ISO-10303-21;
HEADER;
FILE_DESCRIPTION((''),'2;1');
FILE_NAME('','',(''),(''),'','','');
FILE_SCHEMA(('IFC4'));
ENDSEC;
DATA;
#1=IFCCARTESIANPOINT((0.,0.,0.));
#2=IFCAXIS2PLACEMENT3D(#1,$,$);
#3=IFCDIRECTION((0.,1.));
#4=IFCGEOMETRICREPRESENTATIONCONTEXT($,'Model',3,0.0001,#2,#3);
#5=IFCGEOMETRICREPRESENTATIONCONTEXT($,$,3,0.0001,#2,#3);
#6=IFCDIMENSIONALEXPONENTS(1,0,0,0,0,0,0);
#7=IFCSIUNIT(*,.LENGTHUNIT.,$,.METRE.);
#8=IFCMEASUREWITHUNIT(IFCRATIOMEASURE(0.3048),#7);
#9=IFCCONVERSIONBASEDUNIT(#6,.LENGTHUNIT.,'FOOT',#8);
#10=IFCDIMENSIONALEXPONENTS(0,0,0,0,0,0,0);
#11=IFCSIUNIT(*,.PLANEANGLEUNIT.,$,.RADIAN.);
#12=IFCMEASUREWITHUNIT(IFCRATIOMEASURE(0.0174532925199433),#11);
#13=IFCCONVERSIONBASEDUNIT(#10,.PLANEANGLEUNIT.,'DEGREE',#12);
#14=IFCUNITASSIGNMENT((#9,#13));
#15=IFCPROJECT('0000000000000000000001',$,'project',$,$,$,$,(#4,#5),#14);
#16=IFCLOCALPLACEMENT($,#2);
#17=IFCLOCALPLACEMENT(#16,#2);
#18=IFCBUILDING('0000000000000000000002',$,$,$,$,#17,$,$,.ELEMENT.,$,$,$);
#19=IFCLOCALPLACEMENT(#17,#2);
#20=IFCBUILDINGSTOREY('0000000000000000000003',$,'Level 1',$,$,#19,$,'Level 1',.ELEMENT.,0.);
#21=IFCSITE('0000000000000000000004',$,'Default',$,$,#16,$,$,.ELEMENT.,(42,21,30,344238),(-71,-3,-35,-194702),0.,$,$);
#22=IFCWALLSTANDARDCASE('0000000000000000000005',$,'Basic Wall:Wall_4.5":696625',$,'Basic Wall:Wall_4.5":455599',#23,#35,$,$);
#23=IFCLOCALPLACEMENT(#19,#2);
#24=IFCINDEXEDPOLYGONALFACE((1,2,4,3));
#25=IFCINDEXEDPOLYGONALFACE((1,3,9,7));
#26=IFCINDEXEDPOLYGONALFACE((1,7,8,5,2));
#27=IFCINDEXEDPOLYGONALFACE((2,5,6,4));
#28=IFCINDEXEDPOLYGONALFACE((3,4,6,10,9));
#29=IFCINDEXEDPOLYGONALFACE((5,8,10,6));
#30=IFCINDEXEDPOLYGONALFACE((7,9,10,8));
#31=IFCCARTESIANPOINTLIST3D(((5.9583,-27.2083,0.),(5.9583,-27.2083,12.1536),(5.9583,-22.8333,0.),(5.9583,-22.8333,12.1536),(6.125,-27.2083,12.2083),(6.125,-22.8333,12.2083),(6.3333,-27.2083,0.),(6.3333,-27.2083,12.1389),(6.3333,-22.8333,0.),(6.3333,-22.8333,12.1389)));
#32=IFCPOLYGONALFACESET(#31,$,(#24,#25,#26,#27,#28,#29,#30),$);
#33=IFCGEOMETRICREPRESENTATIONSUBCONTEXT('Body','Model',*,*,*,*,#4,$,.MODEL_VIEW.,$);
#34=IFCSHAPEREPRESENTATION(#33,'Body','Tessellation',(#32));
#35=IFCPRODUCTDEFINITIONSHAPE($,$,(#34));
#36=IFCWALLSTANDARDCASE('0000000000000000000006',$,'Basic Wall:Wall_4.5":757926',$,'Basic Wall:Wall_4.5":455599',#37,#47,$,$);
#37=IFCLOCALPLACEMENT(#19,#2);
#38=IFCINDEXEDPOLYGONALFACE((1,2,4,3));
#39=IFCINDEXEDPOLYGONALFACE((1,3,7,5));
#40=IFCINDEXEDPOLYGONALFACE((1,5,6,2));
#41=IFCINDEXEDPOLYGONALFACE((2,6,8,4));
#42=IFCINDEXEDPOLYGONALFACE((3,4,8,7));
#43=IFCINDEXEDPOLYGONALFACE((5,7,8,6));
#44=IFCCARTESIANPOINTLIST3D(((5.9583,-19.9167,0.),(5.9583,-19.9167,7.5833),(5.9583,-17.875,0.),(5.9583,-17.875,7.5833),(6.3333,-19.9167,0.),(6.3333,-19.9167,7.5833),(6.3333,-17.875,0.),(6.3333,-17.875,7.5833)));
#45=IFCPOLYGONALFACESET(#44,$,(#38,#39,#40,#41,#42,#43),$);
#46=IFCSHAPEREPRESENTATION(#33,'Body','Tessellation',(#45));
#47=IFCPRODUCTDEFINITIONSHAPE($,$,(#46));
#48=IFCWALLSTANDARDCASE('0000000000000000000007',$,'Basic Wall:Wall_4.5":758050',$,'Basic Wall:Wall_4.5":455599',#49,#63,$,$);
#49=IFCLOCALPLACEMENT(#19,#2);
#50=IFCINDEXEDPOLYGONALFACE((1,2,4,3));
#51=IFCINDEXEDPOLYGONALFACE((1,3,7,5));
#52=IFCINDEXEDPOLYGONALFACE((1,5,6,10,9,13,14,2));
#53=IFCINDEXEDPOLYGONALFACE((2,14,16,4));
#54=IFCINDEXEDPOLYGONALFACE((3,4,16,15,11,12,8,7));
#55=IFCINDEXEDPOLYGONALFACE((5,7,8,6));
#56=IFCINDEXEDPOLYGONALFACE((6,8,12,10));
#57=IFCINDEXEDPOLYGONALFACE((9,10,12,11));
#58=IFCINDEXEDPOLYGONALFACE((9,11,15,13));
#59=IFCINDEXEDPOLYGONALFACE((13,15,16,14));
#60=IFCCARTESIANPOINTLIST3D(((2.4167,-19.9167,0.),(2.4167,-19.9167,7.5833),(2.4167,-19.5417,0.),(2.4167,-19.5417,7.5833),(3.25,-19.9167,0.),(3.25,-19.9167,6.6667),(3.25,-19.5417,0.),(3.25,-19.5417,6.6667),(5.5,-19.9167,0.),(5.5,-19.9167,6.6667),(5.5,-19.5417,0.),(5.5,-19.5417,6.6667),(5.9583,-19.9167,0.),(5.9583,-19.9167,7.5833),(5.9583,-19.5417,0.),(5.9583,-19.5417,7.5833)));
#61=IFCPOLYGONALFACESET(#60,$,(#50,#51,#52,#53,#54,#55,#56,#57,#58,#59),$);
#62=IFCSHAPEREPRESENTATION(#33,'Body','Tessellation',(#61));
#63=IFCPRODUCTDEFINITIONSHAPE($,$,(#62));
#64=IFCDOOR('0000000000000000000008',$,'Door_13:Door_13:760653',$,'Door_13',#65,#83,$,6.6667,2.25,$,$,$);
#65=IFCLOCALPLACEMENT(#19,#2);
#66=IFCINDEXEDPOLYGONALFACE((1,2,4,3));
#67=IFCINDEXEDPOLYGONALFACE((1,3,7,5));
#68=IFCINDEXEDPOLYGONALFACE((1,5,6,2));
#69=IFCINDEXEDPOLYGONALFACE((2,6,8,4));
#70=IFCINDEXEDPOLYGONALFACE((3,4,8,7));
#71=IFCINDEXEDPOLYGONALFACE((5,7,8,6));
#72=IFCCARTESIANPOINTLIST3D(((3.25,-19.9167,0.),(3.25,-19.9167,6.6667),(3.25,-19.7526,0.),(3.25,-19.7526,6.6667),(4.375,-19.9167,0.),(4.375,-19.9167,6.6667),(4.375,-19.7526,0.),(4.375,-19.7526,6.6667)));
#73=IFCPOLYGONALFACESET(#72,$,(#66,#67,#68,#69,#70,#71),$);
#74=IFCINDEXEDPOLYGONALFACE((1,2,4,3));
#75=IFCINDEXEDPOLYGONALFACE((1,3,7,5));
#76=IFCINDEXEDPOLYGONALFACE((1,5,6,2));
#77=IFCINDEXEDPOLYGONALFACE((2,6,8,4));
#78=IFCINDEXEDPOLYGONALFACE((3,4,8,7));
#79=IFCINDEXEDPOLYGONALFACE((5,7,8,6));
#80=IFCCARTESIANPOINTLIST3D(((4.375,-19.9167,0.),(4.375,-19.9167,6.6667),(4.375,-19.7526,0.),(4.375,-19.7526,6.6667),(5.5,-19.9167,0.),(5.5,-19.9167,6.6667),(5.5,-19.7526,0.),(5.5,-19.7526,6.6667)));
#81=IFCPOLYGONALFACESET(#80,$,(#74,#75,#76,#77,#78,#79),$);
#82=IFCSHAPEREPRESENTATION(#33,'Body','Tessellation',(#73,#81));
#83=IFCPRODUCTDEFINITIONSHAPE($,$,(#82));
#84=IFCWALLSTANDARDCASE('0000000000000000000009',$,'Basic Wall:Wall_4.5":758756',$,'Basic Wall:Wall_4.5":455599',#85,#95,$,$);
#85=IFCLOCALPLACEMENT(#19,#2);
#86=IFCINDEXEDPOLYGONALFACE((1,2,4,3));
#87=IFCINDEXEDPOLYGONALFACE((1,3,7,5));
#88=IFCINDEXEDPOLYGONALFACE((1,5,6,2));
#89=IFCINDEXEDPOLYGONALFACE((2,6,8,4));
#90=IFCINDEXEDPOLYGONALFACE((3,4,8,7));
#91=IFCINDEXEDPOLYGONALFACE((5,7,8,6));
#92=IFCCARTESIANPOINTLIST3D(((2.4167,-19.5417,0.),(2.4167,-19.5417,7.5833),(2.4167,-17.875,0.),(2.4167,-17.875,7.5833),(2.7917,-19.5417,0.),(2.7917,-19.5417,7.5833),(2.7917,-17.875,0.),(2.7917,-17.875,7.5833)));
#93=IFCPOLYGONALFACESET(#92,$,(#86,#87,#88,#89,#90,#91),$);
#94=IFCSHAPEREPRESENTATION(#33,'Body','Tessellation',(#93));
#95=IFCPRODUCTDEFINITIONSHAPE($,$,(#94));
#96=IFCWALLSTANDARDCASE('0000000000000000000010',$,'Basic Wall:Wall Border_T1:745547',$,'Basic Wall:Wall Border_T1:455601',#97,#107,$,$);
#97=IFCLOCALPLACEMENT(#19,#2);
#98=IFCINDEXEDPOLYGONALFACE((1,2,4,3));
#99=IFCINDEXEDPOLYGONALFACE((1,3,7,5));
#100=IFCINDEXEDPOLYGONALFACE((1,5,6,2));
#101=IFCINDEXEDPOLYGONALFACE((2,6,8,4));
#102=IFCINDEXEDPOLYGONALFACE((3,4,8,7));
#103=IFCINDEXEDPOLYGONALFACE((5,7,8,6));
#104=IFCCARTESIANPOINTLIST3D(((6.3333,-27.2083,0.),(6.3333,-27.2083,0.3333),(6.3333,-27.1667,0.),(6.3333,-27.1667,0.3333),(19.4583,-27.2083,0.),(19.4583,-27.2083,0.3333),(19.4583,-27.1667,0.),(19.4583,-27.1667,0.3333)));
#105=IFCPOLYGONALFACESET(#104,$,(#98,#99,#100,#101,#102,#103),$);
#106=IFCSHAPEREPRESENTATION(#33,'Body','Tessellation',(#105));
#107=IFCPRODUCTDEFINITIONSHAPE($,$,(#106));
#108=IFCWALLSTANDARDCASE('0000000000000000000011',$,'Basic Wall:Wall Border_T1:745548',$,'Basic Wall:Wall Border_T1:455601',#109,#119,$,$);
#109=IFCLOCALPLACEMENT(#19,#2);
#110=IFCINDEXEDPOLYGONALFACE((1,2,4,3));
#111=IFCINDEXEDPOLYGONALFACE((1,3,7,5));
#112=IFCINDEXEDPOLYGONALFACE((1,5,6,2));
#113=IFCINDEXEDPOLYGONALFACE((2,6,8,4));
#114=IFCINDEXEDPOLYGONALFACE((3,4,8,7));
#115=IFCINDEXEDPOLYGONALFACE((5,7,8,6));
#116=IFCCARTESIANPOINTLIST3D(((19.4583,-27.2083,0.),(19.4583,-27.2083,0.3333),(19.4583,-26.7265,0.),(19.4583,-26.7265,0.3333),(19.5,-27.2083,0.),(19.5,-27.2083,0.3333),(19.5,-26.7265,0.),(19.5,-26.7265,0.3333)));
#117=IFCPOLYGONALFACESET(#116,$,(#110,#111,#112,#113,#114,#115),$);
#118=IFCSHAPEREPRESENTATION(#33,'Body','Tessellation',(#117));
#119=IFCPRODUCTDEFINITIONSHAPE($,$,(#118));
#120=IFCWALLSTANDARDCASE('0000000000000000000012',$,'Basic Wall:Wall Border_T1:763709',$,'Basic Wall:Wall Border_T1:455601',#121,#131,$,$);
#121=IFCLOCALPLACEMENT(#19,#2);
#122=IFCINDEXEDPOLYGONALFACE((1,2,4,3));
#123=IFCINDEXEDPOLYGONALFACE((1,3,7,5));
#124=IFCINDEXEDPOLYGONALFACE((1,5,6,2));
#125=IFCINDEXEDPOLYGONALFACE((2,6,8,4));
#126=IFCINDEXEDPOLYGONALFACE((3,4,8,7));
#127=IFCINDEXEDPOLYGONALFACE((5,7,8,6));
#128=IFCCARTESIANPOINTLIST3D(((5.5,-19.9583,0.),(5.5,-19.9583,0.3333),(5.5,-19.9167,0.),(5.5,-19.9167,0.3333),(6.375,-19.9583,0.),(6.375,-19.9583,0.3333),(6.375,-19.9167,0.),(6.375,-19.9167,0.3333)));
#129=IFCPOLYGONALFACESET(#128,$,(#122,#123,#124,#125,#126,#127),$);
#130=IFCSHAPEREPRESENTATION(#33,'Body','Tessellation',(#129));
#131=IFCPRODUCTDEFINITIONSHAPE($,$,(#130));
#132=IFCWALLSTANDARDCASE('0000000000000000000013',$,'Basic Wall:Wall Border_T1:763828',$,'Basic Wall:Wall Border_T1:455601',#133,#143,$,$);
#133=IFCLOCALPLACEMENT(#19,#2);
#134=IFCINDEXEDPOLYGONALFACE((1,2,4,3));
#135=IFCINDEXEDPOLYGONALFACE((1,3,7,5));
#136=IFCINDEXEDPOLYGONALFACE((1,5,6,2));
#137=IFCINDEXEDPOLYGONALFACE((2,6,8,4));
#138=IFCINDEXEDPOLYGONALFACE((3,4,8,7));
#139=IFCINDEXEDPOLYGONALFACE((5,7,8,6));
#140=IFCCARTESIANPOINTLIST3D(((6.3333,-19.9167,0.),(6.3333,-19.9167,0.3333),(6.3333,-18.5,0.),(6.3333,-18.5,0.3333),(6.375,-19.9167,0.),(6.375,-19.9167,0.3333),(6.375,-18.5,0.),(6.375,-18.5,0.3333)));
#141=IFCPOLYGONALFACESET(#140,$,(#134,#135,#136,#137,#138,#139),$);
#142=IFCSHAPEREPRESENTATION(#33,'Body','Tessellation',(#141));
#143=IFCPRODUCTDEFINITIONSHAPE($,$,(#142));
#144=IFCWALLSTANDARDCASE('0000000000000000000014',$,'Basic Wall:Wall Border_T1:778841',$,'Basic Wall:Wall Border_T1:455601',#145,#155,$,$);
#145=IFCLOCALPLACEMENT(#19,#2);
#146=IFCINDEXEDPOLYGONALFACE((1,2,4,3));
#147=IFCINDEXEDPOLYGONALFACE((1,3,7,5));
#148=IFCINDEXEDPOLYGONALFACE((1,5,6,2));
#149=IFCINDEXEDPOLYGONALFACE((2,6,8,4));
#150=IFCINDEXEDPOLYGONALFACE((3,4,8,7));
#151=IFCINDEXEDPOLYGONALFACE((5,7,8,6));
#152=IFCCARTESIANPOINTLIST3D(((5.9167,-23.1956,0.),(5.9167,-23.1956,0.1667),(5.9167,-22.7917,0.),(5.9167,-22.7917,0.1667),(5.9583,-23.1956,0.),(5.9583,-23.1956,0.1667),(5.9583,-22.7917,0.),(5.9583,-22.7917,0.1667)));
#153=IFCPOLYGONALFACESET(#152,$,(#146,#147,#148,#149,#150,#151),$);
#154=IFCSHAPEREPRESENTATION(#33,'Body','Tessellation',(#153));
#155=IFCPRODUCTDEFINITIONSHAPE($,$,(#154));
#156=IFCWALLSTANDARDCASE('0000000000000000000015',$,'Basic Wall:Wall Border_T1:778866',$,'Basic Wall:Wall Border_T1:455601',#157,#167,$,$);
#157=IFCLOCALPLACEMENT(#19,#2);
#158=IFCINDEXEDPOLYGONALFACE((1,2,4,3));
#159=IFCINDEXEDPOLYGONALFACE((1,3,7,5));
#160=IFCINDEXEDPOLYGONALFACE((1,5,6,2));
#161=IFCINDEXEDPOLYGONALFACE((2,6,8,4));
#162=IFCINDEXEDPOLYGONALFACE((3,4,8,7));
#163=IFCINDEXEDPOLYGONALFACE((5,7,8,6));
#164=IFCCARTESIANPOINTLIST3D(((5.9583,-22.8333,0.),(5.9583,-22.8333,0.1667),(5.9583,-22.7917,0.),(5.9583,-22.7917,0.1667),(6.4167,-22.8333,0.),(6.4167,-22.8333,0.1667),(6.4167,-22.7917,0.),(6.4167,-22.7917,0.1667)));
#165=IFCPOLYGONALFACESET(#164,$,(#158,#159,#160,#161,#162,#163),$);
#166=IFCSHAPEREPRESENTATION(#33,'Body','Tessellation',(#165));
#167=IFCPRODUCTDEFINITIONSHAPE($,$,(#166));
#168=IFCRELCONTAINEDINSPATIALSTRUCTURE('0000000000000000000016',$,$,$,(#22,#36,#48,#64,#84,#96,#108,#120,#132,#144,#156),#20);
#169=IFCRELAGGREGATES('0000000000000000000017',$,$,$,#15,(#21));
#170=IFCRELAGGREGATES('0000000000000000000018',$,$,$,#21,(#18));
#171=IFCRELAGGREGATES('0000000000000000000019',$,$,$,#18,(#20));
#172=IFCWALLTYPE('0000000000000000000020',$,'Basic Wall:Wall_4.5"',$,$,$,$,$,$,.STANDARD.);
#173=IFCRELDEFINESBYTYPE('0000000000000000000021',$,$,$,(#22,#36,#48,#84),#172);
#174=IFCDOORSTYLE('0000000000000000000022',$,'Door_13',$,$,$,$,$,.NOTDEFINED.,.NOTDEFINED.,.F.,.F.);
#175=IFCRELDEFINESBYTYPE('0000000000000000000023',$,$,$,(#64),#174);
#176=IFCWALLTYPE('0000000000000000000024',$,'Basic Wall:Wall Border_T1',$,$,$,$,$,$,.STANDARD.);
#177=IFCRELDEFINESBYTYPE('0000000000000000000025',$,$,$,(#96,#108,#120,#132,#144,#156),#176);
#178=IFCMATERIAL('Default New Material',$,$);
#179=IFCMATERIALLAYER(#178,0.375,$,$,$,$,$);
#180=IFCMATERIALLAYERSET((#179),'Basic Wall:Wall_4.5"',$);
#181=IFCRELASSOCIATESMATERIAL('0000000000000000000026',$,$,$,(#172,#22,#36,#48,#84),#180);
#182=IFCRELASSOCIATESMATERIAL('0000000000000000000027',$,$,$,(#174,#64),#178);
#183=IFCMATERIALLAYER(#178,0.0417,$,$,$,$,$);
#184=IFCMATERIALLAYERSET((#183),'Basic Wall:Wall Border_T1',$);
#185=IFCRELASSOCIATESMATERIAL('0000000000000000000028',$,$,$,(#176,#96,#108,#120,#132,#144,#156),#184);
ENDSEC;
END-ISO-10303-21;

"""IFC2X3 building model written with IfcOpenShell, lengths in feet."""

from ifc_helpers import new_model, entity, si_unit, converted_unit, direction, frame, frame_2d, origin, origin_2d_with_axis, place, context, subcontext, project, spatial, polyline, rectangle, extrude, clip, bounded_halfspace, source, transform, mapped, material, layer, layer_set, layer_usage, type_object, type_shapes, element, fill, save


model = new_model("IFC2X3")

# Units and contexts
model_context = context("Model", 3, precision=0.0001, world=origin(), true_north=direction((0.0, 1.0)))
context_of_model = context(None, 3, precision=0.0001, world=origin(), true_north=direction((0.0, 1.0)))
body_context = subcontext(model_context, "Body", "Model", "MODEL_VIEW")
ifc_project = project(units=[converted_unit("LENGTHUNIT", "FOOT", entity("IfcRatioMeasure", 0.3048), si_unit("LENGTHUNIT", "METRE"), dimensions=[1, 0, 0, 0, 0, 0, 0]), converted_unit("PLANEANGLEUNIT", "DEGREE", entity("IfcRatioMeasure", 0.0174532925199433), si_unit("PLANEANGLEUNIT", "RADIAN"), dimensions=[0, 0, 0, 0, 0, 0, 0])], contexts=[model_context, context_of_model])

# Site, building, storey
site_placement = place(None, origin())
site = spatial("IfcSite", under=ifc_project, at=site_placement, Name="Default", CompositionType="ELEMENT", RefLatitude=(42, 21, 30, 344238), RefLongitude=(-71, -3, -35, -194702), RefElevation=0.0)
building_placement = place(site_placement, origin())
building = spatial("IfcBuilding", under=site, at=building_placement, CompositionType="ELEMENT")
storey_placement = place(building_placement, origin())
storey = spatial("IfcBuildingStorey", under=building, at=storey_placement, Name="Level 1", LongName="Level 1", CompositionType="ELEMENT", Elevation=0.0)

# Walls
ifc_material = material(Name="Default New Material")
ifc_layer_1 = layer(ifc_material, 0.375)
ifc_layer_set_1 = layer_set([ifc_layer_1], Name="Basic Wall:Wall_4.5\"")
ifc_layer_usage_1 = layer_usage(ifc_layer_set_1, "AXIS2", "NEGATIVE", 0.1875)
wall_type_1 = type_object("IfcWallType", Name="Basic Wall:Wall_4.5\"", PredefinedType="STANDARD", material=ifc_layer_set_1)
wall_1_placement = place(storey_placement, frame((6.1458, -27.2083, 0.0), z_axis=(0.0, 0.0, 1.0), x_axis=(0.0, 1.0, 0.0)))
element("IfcWallStandardCase", 1, at=wall_1_placement, inside=storey, type_object=wall_type_1, material=ifc_layer_usage_1, Name="Basic Wall:Wall_4.5\":696625", ObjectType="Basic Wall:Wall_4.5\":455599", context=body_context, shape_type="Clipping", body=[
    clip(clip(extrude(rectangle(XDim=4.375, YDim=0.375, at=frame_2d((2.1875, 0.0), x_axis=(-1.0, 0.0))), origin(), (0.0, 0.0, 1.0), 12.2083), bounded_halfspace(frame((0.0, -0.1875, 12.1389), z_axis=(0.0, 0.316228, -0.948683), x_axis=(-1.0, 0.0, 0.0)), True, frame((0.0, -0.1875, 12.1389)), polyline([(0.0, 0.0), (4.375, 0.0), (4.375, 0.2083), (0.0, 0.2083), (0.0, 0.0)]))), bounded_halfspace(frame((4.375, 0.0208, 12.2083), z_axis=(0.0, -0.311853, -0.95013), x_axis=(-1.0, 0.0, 0.0)), True, frame((4.375, 0.0208, 12.2083)), polyline([(0.0, 0.0), (0.0, 0.1667), (-4.375, 0.1667), (-4.375, 0.0), (0.0, 0.0)]))),
])
ifc_layer_usage_2 = layer_usage(ifc_layer_set_1, "AXIS2", "POSITIVE", -0.1875)
wall_2_placement = place(storey_placement, frame((6.1458, -19.9167, 0.0), z_axis=(0.0, 0.0, 1.0), x_axis=(0.0, 1.0, 0.0)))
element("IfcWallStandardCase", 2, at=wall_2_placement, inside=storey, type_object=wall_type_1, material=ifc_layer_usage_2, Name="Basic Wall:Wall_4.5\":757926", ObjectType="Basic Wall:Wall_4.5\":455599", context=body_context, shape_type="SweptSolid", body=[
    extrude(rectangle(XDim=2.0417, YDim=0.375, at=frame_2d((1.0208, 0.0), x_axis=(-1.0, 0.0))), origin(), (0.0, 0.0, 1.0), 7.5833),
])

# Wall, opening, door
ifc_layer_usage_3 = layer_usage(ifc_layer_set_1, "AXIS2", "POSITIVE", -0.1875)
wall_3_placement = place(storey_placement, frame((5.9583, -19.7292, 0.0), z_axis=(0.0, 0.0, 1.0), x_axis=(-1.0, 0.0, 0.0)))
wall_3 = element("IfcWallStandardCase", 3, at=wall_3_placement, inside=storey, type_object=wall_type_1, material=ifc_layer_usage_3, Name="Basic Wall:Wall_4.5\":758050", ObjectType="Basic Wall:Wall_4.5\":455599", context=body_context, shape_type="SweptSolid", body=[
    extrude(rectangle(XDim=3.5417, YDim=0.375, at=frame_2d((1.7708, 0.0), x_axis=(-1.0, 0.0))), origin(), (0.0, 0.0, 1.0), 7.5833),
])
opening_placement = place(wall_3_placement, frame((0.4583, -0.1875, 0.0)))
opening = element("IfcOpeningElement", 4, at=opening_placement, cuts=wall_3, ObjectType="Opening", context=body_context, shape_type="SweptSolid", body=[
    extrude(rectangle(XDim=6.6667, YDim=2.25, at=frame_2d((3.3333, 1.125), x_axis=(1.0, 0.0))), frame((0.0, 0.0, 0.0), z_axis=(0.0, 1.0, 0.0), x_axis=(0.0, 0.0, 1.0)), (0.0, 0.0, 1.0), 0.375),
])
door_style = type_object("IfcDoorStyle", Name="Door_13", ConstructionType="NOTDEFINED", OperationType="NOTDEFINED", ParameterTakesPrecedence=False, Sizeable=False, material=ifc_material)
shared_shape_1 = source(origin(), body_context, "Body", "SweptSolid", [
    extrude(rectangle(XDim=0.164, YDim=1.125, at=origin_2d_with_axis()), frame((1.6875, 0.293, 0.0), z_axis=(0.0, 0.0, 1.0), x_axis=(0.0, -1.0, 0.0)), (0.0, 0.0, 1.0), 6.6667),
    extrude(rectangle(XDim=0.164, YDim=1.125, at=origin_2d_with_axis()), frame((0.5625, 0.293, 0.0), z_axis=(0.0, 0.0, 1.0), x_axis=(0.0, -1.0, 0.0)), (0.0, 0.0, 1.0), 6.6667),
])
type_shapes(door_style, [shared_shape_1])
door_placement = place(opening_placement, origin())
door = element("IfcDoor", 5, at=door_placement, inside=storey, type_object=door_style, material=ifc_material, Name="Door_13:Door_13:760653", ObjectType="Door_13", OverallHeight=6.6667, OverallWidth=2.25, context=body_context, shape_type="MappedRepresentation", body=[
    mapped(shared_shape_1, transform((0.0, 0.0, 0.0), scale=1.0)),
])
fill(opening, door)

# Walls
ifc_layer_usage_4 = layer_usage(ifc_layer_set_1, "AXIS2", "NEGATIVE", 0.1875)
wall_4_placement = place(storey_placement, frame((2.6042, -17.875, 0.0), z_axis=(0.0, 0.0, 1.0), x_axis=(0.0, -1.0, 0.0)))
element("IfcWallStandardCase", 6, at=wall_4_placement, inside=storey, type_object=wall_type_1, material=ifc_layer_usage_4, Name="Basic Wall:Wall_4.5\":758756", ObjectType="Basic Wall:Wall_4.5\":455599", context=body_context, shape_type="SweptSolid", body=[
    extrude(rectangle(XDim=1.6667, YDim=0.375, at=frame_2d((0.8333, 0.0), x_axis=(-1.0, 0.0))), origin(), (0.0, 0.0, 1.0), 7.5833),
])
ifc_layer_2 = layer(ifc_material, 0.0417)
ifc_layer_set_2 = layer_set([ifc_layer_2], Name="Basic Wall:Wall Border_T1")
ifc_layer_usage_5 = layer_usage(ifc_layer_set_2, "AXIS2", "POSITIVE", -0.0208)
wall_type_2 = type_object("IfcWallType", Name="Basic Wall:Wall Border_T1", PredefinedType="STANDARD", material=ifc_layer_set_2)
wall_5_placement = place(storey_placement, frame((19.4583, -27.1875, 0.0), z_axis=(0.0, 0.0, 1.0), x_axis=(-1.0, 0.0, 0.0)))
element("IfcWallStandardCase", 7, at=wall_5_placement, inside=storey, type_object=wall_type_2, material=ifc_layer_usage_5, Name="Basic Wall:Wall Border_T1:745547", ObjectType="Basic Wall:Wall Border_T1:455601", context=body_context, shape_type="SweptSolid", body=[
    extrude(rectangle(XDim=13.125, YDim=0.0417, at=frame_2d((6.5625, 0.0), x_axis=(-1.0, 0.0))), origin(), (0.0, 0.0, 1.0), 0.3333),
])
ifc_layer_usage_6 = layer_usage(ifc_layer_set_2, "AXIS2", "POSITIVE", -0.0208)
wall_6_placement = place(storey_placement, frame((19.4792, -26.7265, 0.0), z_axis=(0.0, 0.0, 1.0), x_axis=(0.0, -1.0, 0.0)))
element("IfcWallStandardCase", 8, at=wall_6_placement, inside=storey, type_object=wall_type_2, material=ifc_layer_usage_6, Name="Basic Wall:Wall Border_T1:745548", ObjectType="Basic Wall:Wall Border_T1:455601", context=body_context, shape_type="SweptSolid", body=[
    extrude(rectangle(XDim=0.4818, YDim=0.0417, at=frame_2d((0.2409, 0.0), x_axis=(-1.0, 0.0))), origin(), (0.0, 0.0, 1.0), 0.3333),
])
ifc_layer_usage_7 = layer_usage(ifc_layer_set_2, "AXIS2", "POSITIVE", -0.0208)
wall_7_placement = place(storey_placement, frame((5.5, -19.9375, 0.0)))
element("IfcWallStandardCase", 9, at=wall_7_placement, inside=storey, type_object=wall_type_2, material=ifc_layer_usage_7, Name="Basic Wall:Wall Border_T1:763709", ObjectType="Basic Wall:Wall Border_T1:455601", context=body_context, shape_type="SweptSolid", body=[
    extrude(rectangle(XDim=0.875, YDim=0.0417, at=frame_2d((0.4375, 0.0), x_axis=(-1.0, 0.0))), origin(), (0.0, 0.0, 1.0), 0.3333),
])
ifc_layer_usage_8 = layer_usage(ifc_layer_set_2, "AXIS2", "POSITIVE", -0.0208)
wall_8_placement = place(storey_placement, frame((6.3542, -19.9167, 0.0), z_axis=(0.0, 0.0, 1.0), x_axis=(0.0, 1.0, 0.0)))
element("IfcWallStandardCase", 10, at=wall_8_placement, inside=storey, type_object=wall_type_2, material=ifc_layer_usage_8, Name="Basic Wall:Wall Border_T1:763828", ObjectType="Basic Wall:Wall Border_T1:455601", context=body_context, shape_type="SweptSolid", body=[
    extrude(rectangle(XDim=1.4167, YDim=0.0417, at=frame_2d((0.7083, 0.0), x_axis=(-1.0, 0.0))), origin(), (0.0, 0.0, 1.0), 0.3333),
])
ifc_layer_usage_9 = layer_usage(ifc_layer_set_2, "AXIS2", "NEGATIVE", 0.0208)
wall_9_placement = place(storey_placement, frame((5.9375, -23.1956, 0.0), z_axis=(0.0, 0.0, 1.0), x_axis=(0.0, 1.0, 0.0)))
element("IfcWallStandardCase", 11, at=wall_9_placement, inside=storey, type_object=wall_type_2, material=ifc_layer_usage_9, Name="Basic Wall:Wall Border_T1:778841", ObjectType="Basic Wall:Wall Border_T1:455601", context=body_context, shape_type="SweptSolid", body=[
    extrude(rectangle(XDim=0.4039, YDim=0.0417, at=frame_2d((0.202, 0.0), x_axis=(-1.0, 0.0))), origin(), (0.0, 0.0, 1.0), 0.1667),
])
ifc_layer_usage_10 = layer_usage(ifc_layer_set_2, "AXIS2", "NEGATIVE", 0.0208)
wall_10_placement = place(storey_placement, frame((5.9583, -22.8125, 0.0)))
element("IfcWallStandardCase", 12, at=wall_10_placement, inside=storey, type_object=wall_type_2, material=ifc_layer_usage_10, Name="Basic Wall:Wall Border_T1:778866", ObjectType="Basic Wall:Wall Border_T1:455601", context=body_context, shape_type="SweptSolid", body=[
    extrude(rectangle(XDim=0.4583, YDim=0.0417, at=frame_2d((0.2292, 0.0), x_axis=(-1.0, 0.0))), origin(), (0.0, 0.0, 1.0), 0.1667),
])

save(model, "model.ifc")
